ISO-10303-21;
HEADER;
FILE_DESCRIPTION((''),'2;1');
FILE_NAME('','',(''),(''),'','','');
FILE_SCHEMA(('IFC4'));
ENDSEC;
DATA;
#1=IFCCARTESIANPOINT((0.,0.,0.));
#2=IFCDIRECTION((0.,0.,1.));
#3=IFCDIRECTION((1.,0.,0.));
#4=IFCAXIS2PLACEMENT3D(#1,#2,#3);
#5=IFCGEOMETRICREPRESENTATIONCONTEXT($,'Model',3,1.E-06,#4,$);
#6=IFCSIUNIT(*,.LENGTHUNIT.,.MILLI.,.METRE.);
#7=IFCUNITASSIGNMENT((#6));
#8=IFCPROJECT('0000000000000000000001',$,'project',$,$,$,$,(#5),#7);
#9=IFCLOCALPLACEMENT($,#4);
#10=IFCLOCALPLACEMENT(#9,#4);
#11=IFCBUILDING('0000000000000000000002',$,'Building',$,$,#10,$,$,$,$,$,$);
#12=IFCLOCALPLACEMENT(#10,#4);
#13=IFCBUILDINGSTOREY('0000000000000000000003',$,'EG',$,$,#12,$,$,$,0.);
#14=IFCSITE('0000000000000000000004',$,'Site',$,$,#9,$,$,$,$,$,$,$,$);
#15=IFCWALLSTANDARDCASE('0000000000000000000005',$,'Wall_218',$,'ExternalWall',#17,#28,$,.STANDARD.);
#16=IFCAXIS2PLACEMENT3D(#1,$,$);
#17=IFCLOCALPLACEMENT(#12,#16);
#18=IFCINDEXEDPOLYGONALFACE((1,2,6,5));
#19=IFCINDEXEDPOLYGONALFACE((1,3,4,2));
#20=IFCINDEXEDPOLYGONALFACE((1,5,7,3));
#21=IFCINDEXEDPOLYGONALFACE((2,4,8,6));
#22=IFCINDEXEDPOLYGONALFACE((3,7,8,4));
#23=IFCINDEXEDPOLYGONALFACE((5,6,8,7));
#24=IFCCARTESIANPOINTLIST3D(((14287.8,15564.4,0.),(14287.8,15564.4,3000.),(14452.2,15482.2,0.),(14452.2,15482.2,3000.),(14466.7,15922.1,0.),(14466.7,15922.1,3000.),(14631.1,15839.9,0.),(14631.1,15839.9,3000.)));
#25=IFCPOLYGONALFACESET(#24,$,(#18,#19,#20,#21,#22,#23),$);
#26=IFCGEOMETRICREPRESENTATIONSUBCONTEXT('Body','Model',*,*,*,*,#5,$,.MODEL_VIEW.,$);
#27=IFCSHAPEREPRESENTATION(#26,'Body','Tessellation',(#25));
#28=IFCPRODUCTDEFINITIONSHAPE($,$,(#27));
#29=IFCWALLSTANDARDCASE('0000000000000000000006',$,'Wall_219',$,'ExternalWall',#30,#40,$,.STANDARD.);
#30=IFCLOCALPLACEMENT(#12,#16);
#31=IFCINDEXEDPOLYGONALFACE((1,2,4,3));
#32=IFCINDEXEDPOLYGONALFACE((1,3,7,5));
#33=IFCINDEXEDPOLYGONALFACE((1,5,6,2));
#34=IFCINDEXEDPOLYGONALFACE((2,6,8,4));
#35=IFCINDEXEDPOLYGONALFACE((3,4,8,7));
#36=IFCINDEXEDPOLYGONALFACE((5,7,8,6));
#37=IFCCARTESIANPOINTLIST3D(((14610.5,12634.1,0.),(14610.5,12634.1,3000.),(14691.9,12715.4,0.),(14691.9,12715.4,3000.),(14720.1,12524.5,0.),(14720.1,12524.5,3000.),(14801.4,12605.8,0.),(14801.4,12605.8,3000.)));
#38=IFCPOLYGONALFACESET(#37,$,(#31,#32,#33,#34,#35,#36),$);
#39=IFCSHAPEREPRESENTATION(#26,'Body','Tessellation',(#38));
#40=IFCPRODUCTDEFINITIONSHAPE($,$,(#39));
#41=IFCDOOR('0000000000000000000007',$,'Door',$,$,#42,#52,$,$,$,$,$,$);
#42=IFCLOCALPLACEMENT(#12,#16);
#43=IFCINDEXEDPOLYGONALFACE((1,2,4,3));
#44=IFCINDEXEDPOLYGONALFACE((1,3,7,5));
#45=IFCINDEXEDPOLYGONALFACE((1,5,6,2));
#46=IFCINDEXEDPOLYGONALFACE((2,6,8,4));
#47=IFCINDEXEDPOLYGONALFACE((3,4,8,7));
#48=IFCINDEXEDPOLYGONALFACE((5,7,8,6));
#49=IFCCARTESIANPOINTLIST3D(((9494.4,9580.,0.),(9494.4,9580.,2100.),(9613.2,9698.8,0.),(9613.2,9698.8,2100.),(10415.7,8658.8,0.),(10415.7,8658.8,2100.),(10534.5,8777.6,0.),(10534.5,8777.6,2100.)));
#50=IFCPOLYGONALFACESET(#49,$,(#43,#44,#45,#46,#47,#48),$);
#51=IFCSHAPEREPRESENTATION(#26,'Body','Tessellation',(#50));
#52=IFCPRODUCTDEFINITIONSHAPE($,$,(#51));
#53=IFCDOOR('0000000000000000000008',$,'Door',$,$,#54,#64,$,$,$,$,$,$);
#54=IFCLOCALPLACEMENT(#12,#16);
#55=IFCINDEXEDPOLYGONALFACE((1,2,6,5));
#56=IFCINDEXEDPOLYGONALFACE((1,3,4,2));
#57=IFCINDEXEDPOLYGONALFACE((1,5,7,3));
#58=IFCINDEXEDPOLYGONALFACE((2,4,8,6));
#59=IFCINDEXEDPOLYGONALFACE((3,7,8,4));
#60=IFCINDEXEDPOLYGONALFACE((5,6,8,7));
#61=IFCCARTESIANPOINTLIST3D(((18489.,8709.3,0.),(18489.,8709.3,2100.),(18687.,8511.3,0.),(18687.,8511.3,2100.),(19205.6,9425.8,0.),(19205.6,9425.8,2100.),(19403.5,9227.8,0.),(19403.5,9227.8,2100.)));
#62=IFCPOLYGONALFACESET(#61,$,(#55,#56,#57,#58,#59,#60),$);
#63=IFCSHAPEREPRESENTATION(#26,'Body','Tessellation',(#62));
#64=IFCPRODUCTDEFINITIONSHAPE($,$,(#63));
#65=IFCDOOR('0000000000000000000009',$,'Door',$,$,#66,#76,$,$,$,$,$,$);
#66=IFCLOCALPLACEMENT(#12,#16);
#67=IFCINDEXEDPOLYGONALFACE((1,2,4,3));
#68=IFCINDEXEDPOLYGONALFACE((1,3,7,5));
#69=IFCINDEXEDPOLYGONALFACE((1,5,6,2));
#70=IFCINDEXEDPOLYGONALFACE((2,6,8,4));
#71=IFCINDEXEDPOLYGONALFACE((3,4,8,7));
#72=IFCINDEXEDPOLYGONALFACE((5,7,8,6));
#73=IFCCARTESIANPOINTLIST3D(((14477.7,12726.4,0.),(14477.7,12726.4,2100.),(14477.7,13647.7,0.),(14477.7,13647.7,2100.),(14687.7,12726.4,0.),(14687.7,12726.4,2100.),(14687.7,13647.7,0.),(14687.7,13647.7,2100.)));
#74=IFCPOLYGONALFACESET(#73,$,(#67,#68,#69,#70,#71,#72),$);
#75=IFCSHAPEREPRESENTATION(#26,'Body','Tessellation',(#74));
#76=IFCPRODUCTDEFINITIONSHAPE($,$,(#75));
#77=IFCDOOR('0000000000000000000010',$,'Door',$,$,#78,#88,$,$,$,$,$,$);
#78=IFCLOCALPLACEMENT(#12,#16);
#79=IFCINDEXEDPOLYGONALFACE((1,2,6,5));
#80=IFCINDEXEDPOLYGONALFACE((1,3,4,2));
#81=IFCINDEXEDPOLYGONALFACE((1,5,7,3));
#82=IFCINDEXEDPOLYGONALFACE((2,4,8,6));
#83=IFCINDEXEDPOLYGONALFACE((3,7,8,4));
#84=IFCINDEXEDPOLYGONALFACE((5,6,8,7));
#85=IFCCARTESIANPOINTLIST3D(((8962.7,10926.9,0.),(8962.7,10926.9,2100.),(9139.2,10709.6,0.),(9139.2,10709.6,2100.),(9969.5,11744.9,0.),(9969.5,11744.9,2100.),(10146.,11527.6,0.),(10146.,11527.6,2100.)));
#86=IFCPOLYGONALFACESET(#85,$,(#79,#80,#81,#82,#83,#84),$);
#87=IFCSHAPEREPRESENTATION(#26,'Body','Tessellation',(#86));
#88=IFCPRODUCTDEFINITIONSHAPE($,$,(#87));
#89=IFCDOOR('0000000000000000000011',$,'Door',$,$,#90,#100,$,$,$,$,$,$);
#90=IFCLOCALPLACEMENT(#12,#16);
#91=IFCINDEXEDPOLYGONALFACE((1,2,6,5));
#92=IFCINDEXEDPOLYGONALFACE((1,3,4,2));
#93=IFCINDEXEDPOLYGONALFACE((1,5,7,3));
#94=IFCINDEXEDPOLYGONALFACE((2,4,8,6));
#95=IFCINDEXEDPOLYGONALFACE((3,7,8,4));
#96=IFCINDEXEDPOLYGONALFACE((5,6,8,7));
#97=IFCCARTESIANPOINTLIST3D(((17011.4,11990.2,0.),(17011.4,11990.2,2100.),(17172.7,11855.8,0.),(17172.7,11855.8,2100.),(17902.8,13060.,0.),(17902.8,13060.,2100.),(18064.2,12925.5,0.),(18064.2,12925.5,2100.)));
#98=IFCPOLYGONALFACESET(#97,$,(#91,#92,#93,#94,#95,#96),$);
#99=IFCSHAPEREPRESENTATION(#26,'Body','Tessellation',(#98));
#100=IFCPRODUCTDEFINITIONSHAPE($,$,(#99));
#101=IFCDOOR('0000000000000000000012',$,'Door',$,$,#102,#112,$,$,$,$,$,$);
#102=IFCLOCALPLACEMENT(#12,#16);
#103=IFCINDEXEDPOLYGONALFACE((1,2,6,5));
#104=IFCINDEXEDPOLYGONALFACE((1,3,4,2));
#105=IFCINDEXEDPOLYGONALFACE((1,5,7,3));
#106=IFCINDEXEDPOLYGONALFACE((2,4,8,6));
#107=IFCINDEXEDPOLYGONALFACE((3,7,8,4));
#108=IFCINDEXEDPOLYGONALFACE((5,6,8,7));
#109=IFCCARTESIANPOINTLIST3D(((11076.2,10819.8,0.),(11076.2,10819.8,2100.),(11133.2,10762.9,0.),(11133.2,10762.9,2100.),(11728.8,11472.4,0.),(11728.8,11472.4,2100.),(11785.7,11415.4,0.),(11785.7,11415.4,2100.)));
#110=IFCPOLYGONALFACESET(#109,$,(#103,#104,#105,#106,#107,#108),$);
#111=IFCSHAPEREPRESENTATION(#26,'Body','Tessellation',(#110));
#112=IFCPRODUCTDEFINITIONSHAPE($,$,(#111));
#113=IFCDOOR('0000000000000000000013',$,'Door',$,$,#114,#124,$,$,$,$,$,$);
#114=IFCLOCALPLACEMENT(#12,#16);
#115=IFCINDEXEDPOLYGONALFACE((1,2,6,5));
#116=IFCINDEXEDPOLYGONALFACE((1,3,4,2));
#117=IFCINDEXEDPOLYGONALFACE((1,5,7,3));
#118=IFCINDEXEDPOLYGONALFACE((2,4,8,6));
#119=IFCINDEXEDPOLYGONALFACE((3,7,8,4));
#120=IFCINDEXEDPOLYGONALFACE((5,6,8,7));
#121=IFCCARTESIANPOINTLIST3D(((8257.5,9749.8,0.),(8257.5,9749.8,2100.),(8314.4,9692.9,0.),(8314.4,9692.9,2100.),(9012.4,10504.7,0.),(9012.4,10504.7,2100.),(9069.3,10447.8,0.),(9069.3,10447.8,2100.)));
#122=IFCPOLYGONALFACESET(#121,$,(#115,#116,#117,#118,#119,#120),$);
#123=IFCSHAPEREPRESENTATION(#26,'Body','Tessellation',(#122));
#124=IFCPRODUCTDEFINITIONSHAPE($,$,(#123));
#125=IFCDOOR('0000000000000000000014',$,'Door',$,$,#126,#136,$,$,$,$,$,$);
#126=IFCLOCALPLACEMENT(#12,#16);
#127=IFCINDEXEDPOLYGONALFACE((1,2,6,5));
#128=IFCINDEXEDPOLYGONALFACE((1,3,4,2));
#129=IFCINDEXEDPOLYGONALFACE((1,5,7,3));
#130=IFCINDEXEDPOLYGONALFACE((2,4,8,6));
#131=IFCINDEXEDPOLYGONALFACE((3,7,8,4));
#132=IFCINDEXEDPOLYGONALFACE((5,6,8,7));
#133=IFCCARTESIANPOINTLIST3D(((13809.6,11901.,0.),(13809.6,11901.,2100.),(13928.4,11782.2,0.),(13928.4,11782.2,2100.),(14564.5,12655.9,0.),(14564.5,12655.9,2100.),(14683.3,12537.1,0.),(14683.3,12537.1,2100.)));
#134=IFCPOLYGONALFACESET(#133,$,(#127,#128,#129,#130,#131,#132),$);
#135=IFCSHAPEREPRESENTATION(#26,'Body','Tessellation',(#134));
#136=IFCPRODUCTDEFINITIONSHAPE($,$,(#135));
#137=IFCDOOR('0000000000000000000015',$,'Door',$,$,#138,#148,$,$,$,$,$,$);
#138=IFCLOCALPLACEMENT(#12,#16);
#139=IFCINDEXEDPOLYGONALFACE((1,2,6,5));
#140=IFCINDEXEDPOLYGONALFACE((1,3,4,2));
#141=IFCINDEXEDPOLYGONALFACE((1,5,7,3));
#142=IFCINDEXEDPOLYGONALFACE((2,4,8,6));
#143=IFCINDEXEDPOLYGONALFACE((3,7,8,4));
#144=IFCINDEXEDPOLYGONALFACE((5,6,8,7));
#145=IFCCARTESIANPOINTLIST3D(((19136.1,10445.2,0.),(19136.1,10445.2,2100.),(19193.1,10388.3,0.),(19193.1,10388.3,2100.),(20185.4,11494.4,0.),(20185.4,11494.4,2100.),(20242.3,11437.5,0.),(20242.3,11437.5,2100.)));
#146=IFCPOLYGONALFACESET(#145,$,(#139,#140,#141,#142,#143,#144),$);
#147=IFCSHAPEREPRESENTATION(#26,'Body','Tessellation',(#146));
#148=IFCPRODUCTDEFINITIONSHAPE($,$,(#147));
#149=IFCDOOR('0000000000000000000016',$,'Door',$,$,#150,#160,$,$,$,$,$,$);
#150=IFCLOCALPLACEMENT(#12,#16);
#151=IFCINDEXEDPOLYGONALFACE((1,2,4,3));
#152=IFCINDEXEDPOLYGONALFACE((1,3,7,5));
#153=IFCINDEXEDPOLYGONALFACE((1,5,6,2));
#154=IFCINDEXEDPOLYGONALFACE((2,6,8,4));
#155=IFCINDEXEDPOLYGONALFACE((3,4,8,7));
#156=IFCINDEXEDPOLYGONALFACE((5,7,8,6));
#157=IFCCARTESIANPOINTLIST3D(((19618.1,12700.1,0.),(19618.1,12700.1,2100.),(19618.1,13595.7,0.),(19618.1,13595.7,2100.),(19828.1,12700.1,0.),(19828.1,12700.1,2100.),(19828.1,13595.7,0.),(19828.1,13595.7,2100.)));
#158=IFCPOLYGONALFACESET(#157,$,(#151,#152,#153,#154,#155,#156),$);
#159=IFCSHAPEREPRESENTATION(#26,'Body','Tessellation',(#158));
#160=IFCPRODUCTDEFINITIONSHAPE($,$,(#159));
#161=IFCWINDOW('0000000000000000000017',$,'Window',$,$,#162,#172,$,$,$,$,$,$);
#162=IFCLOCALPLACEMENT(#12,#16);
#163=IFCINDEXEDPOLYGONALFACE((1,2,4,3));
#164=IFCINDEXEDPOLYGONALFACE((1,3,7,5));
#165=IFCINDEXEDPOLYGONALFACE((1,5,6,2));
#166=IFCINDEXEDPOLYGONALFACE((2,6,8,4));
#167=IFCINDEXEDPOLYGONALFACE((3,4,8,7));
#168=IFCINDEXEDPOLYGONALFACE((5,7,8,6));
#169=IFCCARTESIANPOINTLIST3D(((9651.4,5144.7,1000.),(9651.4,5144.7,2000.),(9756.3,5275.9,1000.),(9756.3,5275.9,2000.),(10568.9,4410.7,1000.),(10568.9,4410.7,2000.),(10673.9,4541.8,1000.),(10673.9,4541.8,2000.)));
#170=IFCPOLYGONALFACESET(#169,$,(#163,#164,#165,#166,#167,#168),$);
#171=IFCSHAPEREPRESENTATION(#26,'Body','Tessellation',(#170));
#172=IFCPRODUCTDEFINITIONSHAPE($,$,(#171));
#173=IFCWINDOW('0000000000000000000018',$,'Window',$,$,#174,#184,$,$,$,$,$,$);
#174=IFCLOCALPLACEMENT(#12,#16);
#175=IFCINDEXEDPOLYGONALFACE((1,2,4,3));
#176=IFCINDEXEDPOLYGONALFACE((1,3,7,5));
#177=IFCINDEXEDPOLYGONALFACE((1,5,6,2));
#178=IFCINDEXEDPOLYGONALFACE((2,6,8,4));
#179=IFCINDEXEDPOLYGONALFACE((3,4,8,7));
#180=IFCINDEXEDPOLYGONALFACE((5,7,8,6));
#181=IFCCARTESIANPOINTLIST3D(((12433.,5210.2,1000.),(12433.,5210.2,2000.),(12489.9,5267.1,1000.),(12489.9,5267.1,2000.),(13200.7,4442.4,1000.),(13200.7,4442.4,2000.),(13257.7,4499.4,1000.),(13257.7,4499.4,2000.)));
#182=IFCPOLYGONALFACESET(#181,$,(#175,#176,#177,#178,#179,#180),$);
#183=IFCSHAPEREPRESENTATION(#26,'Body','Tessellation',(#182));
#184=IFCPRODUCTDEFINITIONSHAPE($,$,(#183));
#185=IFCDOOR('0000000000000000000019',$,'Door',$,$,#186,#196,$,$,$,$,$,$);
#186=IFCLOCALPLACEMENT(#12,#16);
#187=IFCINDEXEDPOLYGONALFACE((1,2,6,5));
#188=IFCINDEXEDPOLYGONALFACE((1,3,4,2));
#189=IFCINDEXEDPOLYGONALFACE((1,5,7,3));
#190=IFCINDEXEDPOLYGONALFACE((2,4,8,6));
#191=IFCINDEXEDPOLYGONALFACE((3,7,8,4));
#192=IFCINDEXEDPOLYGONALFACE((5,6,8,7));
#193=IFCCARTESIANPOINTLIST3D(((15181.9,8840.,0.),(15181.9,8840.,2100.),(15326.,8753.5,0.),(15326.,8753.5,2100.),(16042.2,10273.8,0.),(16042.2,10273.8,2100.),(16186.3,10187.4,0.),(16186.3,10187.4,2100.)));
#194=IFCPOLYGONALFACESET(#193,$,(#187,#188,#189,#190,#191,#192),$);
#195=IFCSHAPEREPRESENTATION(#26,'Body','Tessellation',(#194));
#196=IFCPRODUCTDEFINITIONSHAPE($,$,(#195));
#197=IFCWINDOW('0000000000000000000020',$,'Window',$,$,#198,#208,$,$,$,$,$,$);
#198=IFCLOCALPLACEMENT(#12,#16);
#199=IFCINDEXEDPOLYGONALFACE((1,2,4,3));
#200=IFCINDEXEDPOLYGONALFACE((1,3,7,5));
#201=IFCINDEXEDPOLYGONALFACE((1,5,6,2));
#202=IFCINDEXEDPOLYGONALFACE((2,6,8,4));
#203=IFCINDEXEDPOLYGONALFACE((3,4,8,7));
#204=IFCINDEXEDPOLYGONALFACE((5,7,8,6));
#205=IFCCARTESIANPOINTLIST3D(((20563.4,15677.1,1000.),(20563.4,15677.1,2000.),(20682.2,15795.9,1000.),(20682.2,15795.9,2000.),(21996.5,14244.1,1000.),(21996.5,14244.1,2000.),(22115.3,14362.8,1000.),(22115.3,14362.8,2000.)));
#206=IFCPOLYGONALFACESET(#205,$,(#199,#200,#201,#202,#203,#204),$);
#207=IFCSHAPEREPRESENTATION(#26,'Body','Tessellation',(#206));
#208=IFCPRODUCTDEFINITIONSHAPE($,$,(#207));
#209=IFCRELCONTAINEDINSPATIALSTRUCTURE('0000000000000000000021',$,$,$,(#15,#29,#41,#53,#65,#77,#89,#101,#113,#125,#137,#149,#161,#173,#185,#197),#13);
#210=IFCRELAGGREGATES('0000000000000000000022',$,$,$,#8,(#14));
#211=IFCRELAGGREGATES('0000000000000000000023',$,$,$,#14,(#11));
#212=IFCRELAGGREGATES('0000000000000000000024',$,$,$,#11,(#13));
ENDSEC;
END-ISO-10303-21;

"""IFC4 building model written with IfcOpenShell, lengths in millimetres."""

from ifc_helpers import new_model, si_unit, frame, origin_with_axes, place, context, subcontext, project, spatial, rectangle, extrude, element, save


model = new_model("IFC4")

# Units and contexts
model_context = context("Model", 3, precision=1e-06, world=origin_with_axes())
body_context = subcontext(model_context, "Body", "Model", "MODEL_VIEW")
ifc_project = project(units=[si_unit("LENGTHUNIT", "METRE", prefix="MILLI")], contexts=[model_context])

# Site, building, storey
site_placement = place(None, origin_with_axes())
site = spatial("IfcSite", under=ifc_project, at=site_placement, Name="Site")
building_placement = place(site_placement, origin_with_axes())
building = spatial("IfcBuilding", under=site, at=building_placement, Name="Building")
storey_placement = place(building_placement, origin_with_axes())
storey = spatial("IfcBuildingStorey", under=building, at=storey_placement, Name="EG", Elevation=0.0)

# Walls
wall_1_placement = place(storey_placement, origin_with_axes())
element("IfcWallStandardCase", 1, at=wall_1_placement, inside=storey, Name="Wall_218", ObjectType="ExternalWall", PredefinedType="STANDARD", context=body_context, shape_type="SweptSolid", body=[
    extrude(rectangle(XDim=183.8, YDim=400.0), frame((14459.4, 15702.1, 0.0), z_axis=(0.0, 0.0, 1.0), x_axis=(-0.894427, 0.447214, 0.0)), (0.0, 0.0, 1.0), 3000.0),
])
wall_2_placement = place(storey_placement, origin_with_axes())
element("IfcWallStandardCase", 2, at=wall_2_placement, inside=storey, Name="Wall_219", ObjectType="ExternalWall", PredefinedType="STANDARD", context=body_context, shape_type="SweptSolid", body=[
    extrude(rectangle(XDim=155.0, YDim=115.0), frame((14706.0, 12619.9, 0.0), z_axis=(0.0, 0.0, 1.0), x_axis=(0.707107, -0.707107, 0.0)), (0.0, 0.0, 1.0), 3000.0),
])

# Doors
door_1_placement = place(storey_placement, origin_with_axes())
element("IfcDoor", 3, at=door_1_placement, inside=storey, Name="Door", context=body_context, shape_type="SweptSolid", body=[
    extrude(rectangle(XDim=1302.9, YDim=168.0), frame((10014.4, 9178.8, 0.0), z_axis=(0.0, 0.0, 1.0), x_axis=(0.707107, -0.707107, 0.0)), (0.0, 0.0, 1.0), 2100.0),
])
door_2_placement = place(storey_placement, origin_with_axes())
element("IfcDoor", 4, at=door_2_placement, inside=storey, Name="Door", context=body_context, shape_type="SweptSolid", body=[
    extrude(rectangle(XDim=1013.3, YDim=280.0), frame((18946.3, 8968.5, 0.0), z_axis=(0.0, 0.0, 1.0), x_axis=(-0.707107, -0.707107, 0.0)), (0.0, 0.0, 1.0), 2100.0),
])
door_3_placement = place(storey_placement, origin_with_axes())
element("IfcDoor", 5, at=door_3_placement, inside=storey, Name="Door", context=body_context, shape_type="SweptSolid", body=[
    extrude(rectangle(XDim=921.3, YDim=210.0), frame((14582.7, 13187.1, 0.0), z_axis=(0.0, 0.0, 1.0), x_axis=(0.0, -1.0, 0.0)), (0.0, 0.0, 1.0), 2100.0),
])
door_4_placement = place(storey_placement, origin_with_axes())
element("IfcDoor", 6, at=door_4_placement, inside=storey, Name="Door", context=body_context, shape_type="SweptSolid", body=[
    extrude(rectangle(XDim=1297.2, YDim=280.0), frame((9554.3, 11227.3, 0.0), z_axis=(0.0, 0.0, 1.0), x_axis=(-0.776114, -0.630593, 0.0)), (0.0, 0.0, 1.0), 2100.0),
])
door_5_placement = place(storey_placement, origin_with_axes())
element("IfcDoor", 7, at=door_5_placement, inside=storey, Name="Door", context=body_context, shape_type="SweptSolid", body=[
    extrude(rectangle(XDim=1392.5, YDim=210.0), frame((17537.8, 12457.9, 0.0), z_axis=(0.0, 0.0, 1.0), x_axis=(-0.640184, -0.768221, 0.0)), (0.0, 0.0, 1.0), 2100.0),
])
door_6_placement = place(storey_placement, origin_with_axes())
element("IfcDoor", 8, at=door_6_placement, inside=storey, Name="Door", context=body_context, shape_type="SweptSolid", body=[
    extrude(rectangle(XDim=922.9, YDim=80.5), frame((11431.0, 11117.6, 0.0), z_axis=(0.0, 0.0, 1.0), x_axis=(-0.707107, -0.707107, 0.0)), (0.0, 0.0, 1.0), 2100.0),
])
door_7_placement = place(storey_placement, origin_with_axes())
element("IfcDoor", 9, at=door_7_placement, inside=storey, Name="Door", context=body_context, shape_type="SweptSolid", body=[
    extrude(rectangle(XDim=1067.6, YDim=80.5), frame((8663.4, 10098.8, 0.0), z_axis=(0.0, 0.0, 1.0), x_axis=(0.707107, 0.707107, 0.0)), (0.0, 0.0, 1.0), 2100.0),
])
door_8_placement = place(storey_placement, origin_with_axes())
element("IfcDoor", 10, at=door_8_placement, inside=storey, Name="Door", context=body_context, shape_type="SweptSolid", body=[
    extrude(rectangle(XDim=1067.6, YDim=168.0), frame((14246.5, 12219.1, 0.0), z_axis=(0.0, 0.0, 1.0), x_axis=(-0.707107, -0.707107, 0.0)), (0.0, 0.0, 1.0), 2100.0),
])
door_9_placement = place(storey_placement, origin_with_axes())
element("IfcDoor", 11, at=door_9_placement, inside=storey, Name="Door", context=body_context, shape_type="SweptSolid", body=[
    extrude(rectangle(XDim=1483.8, YDim=80.5), frame((19689.2, 10941.4, 0.0), z_axis=(0.0, 0.0, 1.0), x_axis=(-0.707107, -0.707107, 0.0)), (0.0, 0.0, 1.0), 2100.0),
])
door_10_placement = place(storey_placement, origin_with_axes())
element("IfcDoor", 12, at=door_10_placement, inside=storey, Name="Door", context=body_context, shape_type="SweptSolid", body=[
    extrude(rectangle(XDim=895.7, YDim=210.0), frame((19723.1, 13147.9, 0.0), z_axis=(0.0, 0.0, 1.0), x_axis=(0.0, -1.0, 0.0)), (0.0, 0.0, 1.0), 2100.0),
])

# Windows
window_1_placement = place(storey_placement, origin_with_axes())
element("IfcWindow", 13, at=window_1_placement, inside=storey, Name="Window", context=body_context, shape_type="SweptSolid", body=[
    extrude(rectangle(XDim=1175.0, YDim=168.0), frame((10162.6, 4843.3, 1000.0), z_axis=(0.0, 0.0, 1.0), x_axis=(0.780869, -0.624695, 0.0)), (0.0, 0.0, 1.0), 1000.0),
])
window_2_placement = place(storey_placement, origin_with_axes())
element("IfcWindow", 14, at=window_2_placement, inside=storey, Name="Window", context=body_context, shape_type="SweptSolid", body=[
    extrude(rectangle(XDim=1085.7, YDim=80.5), frame((12845.3, 4854.8, 1000.0), z_axis=(0.0, 0.0, 1.0), x_axis=(0.707107, -0.707107, 0.0)), (0.0, 0.0, 1.0), 1000.0),
])

# Door
door_11_placement = place(storey_placement, origin_with_axes())
element("IfcDoor", 15, at=door_11_placement, inside=storey, Name="Door", context=body_context, shape_type="SweptSolid", body=[
    extrude(rectangle(XDim=1672.1, YDim=168.0), frame((15684.1, 9513.7, 0.0), z_axis=(0.0, 0.0, 1.0), x_axis=(0.514496, 0.857493, 0.0)), (0.0, 0.0, 1.0), 2100.0),
])

# Window
window_3_placement = place(storey_placement, origin_with_axes())
element("IfcWindow", 16, at=window_3_placement, inside=storey, Name="Window", context=body_context, shape_type="SweptSolid", body=[
    extrude(rectangle(XDim=2026.7, YDim=168.0), frame((21339.3, 15020.0, 1000.0), z_axis=(0.0, 0.0, 1.0), x_axis=(0.707107, -0.707107, 0.0)), (0.0, 0.0, 1.0), 1000.0),
])

save(model, "model.ifc")
